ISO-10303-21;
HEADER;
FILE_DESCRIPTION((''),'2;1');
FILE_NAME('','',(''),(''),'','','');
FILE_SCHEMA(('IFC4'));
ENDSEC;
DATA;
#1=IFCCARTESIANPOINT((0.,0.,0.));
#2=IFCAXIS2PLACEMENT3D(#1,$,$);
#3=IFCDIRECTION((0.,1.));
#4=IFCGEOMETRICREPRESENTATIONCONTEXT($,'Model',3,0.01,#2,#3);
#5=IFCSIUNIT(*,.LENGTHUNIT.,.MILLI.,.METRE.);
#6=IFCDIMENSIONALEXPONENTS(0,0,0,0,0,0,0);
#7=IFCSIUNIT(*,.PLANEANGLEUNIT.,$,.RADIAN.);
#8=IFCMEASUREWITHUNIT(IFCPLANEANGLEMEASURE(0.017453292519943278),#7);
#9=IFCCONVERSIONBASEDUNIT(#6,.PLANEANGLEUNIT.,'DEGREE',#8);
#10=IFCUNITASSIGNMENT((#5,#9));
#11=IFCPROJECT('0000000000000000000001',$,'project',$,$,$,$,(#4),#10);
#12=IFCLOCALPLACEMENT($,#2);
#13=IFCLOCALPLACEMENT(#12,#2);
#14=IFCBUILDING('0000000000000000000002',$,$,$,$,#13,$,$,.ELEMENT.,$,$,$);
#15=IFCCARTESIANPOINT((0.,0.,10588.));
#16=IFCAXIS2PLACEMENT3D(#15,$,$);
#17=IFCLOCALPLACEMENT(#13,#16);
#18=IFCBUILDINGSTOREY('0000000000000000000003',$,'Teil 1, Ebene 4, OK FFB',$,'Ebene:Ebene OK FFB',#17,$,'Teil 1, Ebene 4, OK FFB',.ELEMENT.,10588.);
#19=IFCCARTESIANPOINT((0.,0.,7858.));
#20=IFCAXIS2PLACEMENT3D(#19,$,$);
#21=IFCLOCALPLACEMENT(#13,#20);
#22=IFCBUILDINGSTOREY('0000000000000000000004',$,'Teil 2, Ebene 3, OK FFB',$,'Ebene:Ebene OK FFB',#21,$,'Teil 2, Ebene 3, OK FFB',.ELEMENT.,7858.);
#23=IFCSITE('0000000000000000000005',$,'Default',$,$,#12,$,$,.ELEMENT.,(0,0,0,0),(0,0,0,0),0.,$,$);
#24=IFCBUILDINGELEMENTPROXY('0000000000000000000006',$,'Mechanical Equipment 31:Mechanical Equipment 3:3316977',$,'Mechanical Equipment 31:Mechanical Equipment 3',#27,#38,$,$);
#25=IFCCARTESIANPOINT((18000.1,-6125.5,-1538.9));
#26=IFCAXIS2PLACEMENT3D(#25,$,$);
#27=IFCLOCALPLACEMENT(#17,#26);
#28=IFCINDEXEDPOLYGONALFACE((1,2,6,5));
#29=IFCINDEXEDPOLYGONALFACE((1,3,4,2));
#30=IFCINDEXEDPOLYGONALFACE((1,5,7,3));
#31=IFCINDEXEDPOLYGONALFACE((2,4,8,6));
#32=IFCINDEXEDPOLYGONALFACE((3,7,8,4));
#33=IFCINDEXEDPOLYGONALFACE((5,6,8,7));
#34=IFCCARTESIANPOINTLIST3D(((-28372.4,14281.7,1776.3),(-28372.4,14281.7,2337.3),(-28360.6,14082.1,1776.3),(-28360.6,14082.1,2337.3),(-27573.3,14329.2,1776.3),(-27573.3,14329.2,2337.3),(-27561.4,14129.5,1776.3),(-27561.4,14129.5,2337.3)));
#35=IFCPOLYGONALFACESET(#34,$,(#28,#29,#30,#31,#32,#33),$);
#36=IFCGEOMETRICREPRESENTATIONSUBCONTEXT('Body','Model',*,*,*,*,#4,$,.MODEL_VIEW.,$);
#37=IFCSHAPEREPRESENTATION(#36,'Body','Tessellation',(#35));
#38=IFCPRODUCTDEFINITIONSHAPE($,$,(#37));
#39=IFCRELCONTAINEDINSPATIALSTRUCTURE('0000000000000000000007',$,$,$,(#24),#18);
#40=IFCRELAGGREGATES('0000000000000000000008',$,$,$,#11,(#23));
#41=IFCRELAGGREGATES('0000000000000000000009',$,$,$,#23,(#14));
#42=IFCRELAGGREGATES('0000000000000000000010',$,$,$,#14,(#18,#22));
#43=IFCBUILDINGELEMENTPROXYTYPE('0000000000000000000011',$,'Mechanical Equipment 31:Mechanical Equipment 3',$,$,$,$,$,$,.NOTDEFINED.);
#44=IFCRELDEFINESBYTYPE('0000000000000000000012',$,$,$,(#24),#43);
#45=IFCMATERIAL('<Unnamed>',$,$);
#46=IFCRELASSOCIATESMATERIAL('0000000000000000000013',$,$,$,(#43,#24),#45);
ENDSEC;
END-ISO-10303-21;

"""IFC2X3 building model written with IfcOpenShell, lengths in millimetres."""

from ifc_helpers import new_model, entity, si_unit, converted_unit, direction, frame, frame_2d, origin, place, context, subcontext, project, spatial, rectangle, extrude, source, transform, mapped, material, type_object, type_shapes, element, save


model = new_model("IFC2X3")

# Units and contexts
model_context = context("Model", 3, precision=0.01, world=origin(), true_north=direction((0.0, 1.0)))
body_context = subcontext(model_context, "Body", "Model", "MODEL_VIEW")
ifc_project = project(units=[si_unit("LENGTHUNIT", "METRE", prefix="MILLI"), converted_unit("PLANEANGLEUNIT", "DEGREE", entity("IfcPlaneAngleMeasure", 0.017453292519943278), si_unit("PLANEANGLEUNIT", "RADIAN"), dimensions=[0, 0, 0, 0, 0, 0, 0])], contexts=[model_context])

# Site, building, storey
site_placement = place(None, origin())
site = spatial("IfcSite", under=ifc_project, at=site_placement, Name="Default", CompositionType="ELEMENT", RefLatitude=(0, 0, 0, 0), RefLongitude=(0, 0, 0, 0), RefElevation=0.0)
building_placement = place(site_placement, origin())
building = spatial("IfcBuilding", under=site, at=building_placement, CompositionType="ELEMENT")
storey_1_placement = place(building_placement, frame((0.0, 0.0, 10588.0)))
storey_1 = spatial("IfcBuildingStorey", under=building, at=storey_1_placement, Name="Teil 1, Ebene 4, OK FFB", ObjectType="Ebene:Ebene OK FFB", LongName="Teil 1, Ebene 4, OK FFB", CompositionType="ELEMENT", Elevation=10588.0)

# Shared definitions
storey_2_placement = place(building_placement, frame((0.0, 0.0, 7858.0)))
storey_2 = spatial("IfcBuildingStorey", under=building, at=storey_2_placement, Name="Teil 2, Ebene 3, OK FFB", ObjectType="Ebene:Ebene OK FFB", LongName="Teil 2, Ebene 3, OK FFB", CompositionType="ELEMENT", Elevation=7858.0)

# Building element proxy
ifc_material_1 = material(Name="<Unnamed>")
building_element_proxy_type = type_object("IfcBuildingElementProxyType", Name="Mechanical Equipment 31:Mechanical Equipment 3", PredefinedType="NOTDEFINED", material=ifc_material_1)
shared_shape_1 = source(origin(), body_context, "Body", "SweptSolid", [
    extrude(rectangle(XDim=200.0, YDim=800.5, at=frame_2d((0.0, 0.0), x_axis=(1.0, 0.0))), frame((-27966.9, 14205.6, 1776.3), z_axis=(0.0, 0.0, 1.0), x_axis=(0.059319, -0.998239, 0.0)), (0.0, 0.0, 1.0), 561.1),
])
type_shapes(building_element_proxy_type, [shared_shape_1])
proxy_placement = place(storey_1_placement, frame((18000.1, -6125.5, -1538.9)))
element("IfcBuildingElementProxy", 1, at=proxy_placement, inside=storey_1, type_object=building_element_proxy_type, material=ifc_material_1, Name="Mechanical Equipment 31:Mechanical Equipment 3:3316977", ObjectType="Mechanical Equipment 31:Mechanical Equipment 3", context=body_context, shape_type="MappedRepresentation", body=[
    mapped(shared_shape_1, transform((0.0, 0.0, 0.0), scale=1.0)),
])

save(model, "model.ifc")
